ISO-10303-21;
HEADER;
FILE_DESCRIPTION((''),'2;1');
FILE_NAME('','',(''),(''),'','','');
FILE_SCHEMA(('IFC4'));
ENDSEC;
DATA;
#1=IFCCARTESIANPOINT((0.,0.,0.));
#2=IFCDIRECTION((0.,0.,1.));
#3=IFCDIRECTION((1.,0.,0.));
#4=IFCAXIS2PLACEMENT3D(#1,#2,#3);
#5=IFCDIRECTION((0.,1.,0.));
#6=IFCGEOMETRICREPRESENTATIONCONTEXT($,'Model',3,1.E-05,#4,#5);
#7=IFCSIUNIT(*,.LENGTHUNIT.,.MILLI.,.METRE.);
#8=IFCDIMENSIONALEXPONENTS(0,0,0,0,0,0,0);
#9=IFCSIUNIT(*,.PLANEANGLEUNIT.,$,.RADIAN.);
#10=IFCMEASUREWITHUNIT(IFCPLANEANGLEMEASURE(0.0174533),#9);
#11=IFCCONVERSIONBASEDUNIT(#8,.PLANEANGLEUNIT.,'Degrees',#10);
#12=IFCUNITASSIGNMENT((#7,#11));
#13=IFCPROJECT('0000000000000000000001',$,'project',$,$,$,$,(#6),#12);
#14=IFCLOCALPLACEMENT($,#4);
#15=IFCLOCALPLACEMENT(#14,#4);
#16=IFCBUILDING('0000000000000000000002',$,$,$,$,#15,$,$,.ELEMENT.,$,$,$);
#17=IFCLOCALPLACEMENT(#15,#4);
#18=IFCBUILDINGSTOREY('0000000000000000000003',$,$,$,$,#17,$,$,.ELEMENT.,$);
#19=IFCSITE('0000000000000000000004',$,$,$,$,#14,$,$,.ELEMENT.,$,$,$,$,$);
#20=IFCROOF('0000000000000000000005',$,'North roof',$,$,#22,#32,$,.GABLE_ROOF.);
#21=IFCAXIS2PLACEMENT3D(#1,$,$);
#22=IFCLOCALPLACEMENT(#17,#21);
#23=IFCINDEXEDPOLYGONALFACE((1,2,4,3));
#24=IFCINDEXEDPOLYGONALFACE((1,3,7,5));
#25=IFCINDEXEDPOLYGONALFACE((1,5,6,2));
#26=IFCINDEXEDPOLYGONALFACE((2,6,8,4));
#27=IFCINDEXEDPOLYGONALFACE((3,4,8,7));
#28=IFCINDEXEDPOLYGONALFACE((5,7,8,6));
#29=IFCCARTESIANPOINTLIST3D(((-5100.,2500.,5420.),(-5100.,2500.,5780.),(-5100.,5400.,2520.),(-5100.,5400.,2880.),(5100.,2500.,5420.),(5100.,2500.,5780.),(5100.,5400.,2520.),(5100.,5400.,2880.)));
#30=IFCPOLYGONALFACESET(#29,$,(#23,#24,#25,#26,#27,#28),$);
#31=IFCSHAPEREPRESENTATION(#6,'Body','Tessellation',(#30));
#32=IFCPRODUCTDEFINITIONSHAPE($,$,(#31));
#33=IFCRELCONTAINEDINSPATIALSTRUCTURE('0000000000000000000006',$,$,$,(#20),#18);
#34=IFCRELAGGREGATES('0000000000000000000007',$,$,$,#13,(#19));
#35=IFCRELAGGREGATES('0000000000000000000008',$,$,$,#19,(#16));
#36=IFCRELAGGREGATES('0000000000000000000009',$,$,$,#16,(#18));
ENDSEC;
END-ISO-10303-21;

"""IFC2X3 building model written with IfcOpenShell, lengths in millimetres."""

from ifc_helpers import new_model, entity, si_unit, converted_unit, direction, frame, origin_with_axes, place, context, project, spatial, polyline, outline, extrude, element, save


model = new_model("IFC2X3")

# Units and contexts
model_context = context("Model", 3, precision=1e-05, world=origin_with_axes(), true_north=direction((0.0, 1.0, 0.0)))
ifc_project = project(units=[si_unit("LENGTHUNIT", "METRE", prefix="MILLI"), converted_unit("PLANEANGLEUNIT", "Degrees", entity("IfcPlaneAngleMeasure", 0.0174533), si_unit("PLANEANGLEUNIT", "RADIAN"), dimensions=[0, 0, 0, 0, 0, 0, 0])], contexts=[model_context])

# Site, building, storey
site_placement = place(None, origin_with_axes())
site = spatial("IfcSite", under=ifc_project, at=site_placement, CompositionType="ELEMENT")
building_placement = place(site_placement, origin_with_axes())
building = spatial("IfcBuilding", under=site, at=building_placement, CompositionType="ELEMENT")
storey_placement = place(building_placement, origin_with_axes())
storey = spatial("IfcBuildingStorey", under=building, at=storey_placement, CompositionType="ELEMENT")

# Roof
for number, where, z_axis, x_axis, name in (
    (1, (0.0, 5400.0, 2700.0), (0.0, 0.0, 1.0), (-1.0, 0.0, 0.0), "North roof"),
):
    element("IfcRoof", number, at=place(storey_placement, frame(where, z_axis=z_axis, x_axis=x_axis)), inside=storey, Name=name, ShapeType="GABLE_ROOF", context=model_context, shape_type="SweptSolid", body=[
        extrude(outline(polyline([(-5100.0, -180.0), (5100.0, -180.0), (5100.0, 180.0), (-5100.0, 180.0), (-5100.0, -180.0), (-5100.0, -180.0)])), frame((0.0, 0.0, 0.0), z_axis=(0.0, 1.0, 0.0), x_axis=(1.0, 0.0, 0.0)), (0.0, -0.707107, 0.707107), 4101.2),
    ])

save(model, "model.ifc")
